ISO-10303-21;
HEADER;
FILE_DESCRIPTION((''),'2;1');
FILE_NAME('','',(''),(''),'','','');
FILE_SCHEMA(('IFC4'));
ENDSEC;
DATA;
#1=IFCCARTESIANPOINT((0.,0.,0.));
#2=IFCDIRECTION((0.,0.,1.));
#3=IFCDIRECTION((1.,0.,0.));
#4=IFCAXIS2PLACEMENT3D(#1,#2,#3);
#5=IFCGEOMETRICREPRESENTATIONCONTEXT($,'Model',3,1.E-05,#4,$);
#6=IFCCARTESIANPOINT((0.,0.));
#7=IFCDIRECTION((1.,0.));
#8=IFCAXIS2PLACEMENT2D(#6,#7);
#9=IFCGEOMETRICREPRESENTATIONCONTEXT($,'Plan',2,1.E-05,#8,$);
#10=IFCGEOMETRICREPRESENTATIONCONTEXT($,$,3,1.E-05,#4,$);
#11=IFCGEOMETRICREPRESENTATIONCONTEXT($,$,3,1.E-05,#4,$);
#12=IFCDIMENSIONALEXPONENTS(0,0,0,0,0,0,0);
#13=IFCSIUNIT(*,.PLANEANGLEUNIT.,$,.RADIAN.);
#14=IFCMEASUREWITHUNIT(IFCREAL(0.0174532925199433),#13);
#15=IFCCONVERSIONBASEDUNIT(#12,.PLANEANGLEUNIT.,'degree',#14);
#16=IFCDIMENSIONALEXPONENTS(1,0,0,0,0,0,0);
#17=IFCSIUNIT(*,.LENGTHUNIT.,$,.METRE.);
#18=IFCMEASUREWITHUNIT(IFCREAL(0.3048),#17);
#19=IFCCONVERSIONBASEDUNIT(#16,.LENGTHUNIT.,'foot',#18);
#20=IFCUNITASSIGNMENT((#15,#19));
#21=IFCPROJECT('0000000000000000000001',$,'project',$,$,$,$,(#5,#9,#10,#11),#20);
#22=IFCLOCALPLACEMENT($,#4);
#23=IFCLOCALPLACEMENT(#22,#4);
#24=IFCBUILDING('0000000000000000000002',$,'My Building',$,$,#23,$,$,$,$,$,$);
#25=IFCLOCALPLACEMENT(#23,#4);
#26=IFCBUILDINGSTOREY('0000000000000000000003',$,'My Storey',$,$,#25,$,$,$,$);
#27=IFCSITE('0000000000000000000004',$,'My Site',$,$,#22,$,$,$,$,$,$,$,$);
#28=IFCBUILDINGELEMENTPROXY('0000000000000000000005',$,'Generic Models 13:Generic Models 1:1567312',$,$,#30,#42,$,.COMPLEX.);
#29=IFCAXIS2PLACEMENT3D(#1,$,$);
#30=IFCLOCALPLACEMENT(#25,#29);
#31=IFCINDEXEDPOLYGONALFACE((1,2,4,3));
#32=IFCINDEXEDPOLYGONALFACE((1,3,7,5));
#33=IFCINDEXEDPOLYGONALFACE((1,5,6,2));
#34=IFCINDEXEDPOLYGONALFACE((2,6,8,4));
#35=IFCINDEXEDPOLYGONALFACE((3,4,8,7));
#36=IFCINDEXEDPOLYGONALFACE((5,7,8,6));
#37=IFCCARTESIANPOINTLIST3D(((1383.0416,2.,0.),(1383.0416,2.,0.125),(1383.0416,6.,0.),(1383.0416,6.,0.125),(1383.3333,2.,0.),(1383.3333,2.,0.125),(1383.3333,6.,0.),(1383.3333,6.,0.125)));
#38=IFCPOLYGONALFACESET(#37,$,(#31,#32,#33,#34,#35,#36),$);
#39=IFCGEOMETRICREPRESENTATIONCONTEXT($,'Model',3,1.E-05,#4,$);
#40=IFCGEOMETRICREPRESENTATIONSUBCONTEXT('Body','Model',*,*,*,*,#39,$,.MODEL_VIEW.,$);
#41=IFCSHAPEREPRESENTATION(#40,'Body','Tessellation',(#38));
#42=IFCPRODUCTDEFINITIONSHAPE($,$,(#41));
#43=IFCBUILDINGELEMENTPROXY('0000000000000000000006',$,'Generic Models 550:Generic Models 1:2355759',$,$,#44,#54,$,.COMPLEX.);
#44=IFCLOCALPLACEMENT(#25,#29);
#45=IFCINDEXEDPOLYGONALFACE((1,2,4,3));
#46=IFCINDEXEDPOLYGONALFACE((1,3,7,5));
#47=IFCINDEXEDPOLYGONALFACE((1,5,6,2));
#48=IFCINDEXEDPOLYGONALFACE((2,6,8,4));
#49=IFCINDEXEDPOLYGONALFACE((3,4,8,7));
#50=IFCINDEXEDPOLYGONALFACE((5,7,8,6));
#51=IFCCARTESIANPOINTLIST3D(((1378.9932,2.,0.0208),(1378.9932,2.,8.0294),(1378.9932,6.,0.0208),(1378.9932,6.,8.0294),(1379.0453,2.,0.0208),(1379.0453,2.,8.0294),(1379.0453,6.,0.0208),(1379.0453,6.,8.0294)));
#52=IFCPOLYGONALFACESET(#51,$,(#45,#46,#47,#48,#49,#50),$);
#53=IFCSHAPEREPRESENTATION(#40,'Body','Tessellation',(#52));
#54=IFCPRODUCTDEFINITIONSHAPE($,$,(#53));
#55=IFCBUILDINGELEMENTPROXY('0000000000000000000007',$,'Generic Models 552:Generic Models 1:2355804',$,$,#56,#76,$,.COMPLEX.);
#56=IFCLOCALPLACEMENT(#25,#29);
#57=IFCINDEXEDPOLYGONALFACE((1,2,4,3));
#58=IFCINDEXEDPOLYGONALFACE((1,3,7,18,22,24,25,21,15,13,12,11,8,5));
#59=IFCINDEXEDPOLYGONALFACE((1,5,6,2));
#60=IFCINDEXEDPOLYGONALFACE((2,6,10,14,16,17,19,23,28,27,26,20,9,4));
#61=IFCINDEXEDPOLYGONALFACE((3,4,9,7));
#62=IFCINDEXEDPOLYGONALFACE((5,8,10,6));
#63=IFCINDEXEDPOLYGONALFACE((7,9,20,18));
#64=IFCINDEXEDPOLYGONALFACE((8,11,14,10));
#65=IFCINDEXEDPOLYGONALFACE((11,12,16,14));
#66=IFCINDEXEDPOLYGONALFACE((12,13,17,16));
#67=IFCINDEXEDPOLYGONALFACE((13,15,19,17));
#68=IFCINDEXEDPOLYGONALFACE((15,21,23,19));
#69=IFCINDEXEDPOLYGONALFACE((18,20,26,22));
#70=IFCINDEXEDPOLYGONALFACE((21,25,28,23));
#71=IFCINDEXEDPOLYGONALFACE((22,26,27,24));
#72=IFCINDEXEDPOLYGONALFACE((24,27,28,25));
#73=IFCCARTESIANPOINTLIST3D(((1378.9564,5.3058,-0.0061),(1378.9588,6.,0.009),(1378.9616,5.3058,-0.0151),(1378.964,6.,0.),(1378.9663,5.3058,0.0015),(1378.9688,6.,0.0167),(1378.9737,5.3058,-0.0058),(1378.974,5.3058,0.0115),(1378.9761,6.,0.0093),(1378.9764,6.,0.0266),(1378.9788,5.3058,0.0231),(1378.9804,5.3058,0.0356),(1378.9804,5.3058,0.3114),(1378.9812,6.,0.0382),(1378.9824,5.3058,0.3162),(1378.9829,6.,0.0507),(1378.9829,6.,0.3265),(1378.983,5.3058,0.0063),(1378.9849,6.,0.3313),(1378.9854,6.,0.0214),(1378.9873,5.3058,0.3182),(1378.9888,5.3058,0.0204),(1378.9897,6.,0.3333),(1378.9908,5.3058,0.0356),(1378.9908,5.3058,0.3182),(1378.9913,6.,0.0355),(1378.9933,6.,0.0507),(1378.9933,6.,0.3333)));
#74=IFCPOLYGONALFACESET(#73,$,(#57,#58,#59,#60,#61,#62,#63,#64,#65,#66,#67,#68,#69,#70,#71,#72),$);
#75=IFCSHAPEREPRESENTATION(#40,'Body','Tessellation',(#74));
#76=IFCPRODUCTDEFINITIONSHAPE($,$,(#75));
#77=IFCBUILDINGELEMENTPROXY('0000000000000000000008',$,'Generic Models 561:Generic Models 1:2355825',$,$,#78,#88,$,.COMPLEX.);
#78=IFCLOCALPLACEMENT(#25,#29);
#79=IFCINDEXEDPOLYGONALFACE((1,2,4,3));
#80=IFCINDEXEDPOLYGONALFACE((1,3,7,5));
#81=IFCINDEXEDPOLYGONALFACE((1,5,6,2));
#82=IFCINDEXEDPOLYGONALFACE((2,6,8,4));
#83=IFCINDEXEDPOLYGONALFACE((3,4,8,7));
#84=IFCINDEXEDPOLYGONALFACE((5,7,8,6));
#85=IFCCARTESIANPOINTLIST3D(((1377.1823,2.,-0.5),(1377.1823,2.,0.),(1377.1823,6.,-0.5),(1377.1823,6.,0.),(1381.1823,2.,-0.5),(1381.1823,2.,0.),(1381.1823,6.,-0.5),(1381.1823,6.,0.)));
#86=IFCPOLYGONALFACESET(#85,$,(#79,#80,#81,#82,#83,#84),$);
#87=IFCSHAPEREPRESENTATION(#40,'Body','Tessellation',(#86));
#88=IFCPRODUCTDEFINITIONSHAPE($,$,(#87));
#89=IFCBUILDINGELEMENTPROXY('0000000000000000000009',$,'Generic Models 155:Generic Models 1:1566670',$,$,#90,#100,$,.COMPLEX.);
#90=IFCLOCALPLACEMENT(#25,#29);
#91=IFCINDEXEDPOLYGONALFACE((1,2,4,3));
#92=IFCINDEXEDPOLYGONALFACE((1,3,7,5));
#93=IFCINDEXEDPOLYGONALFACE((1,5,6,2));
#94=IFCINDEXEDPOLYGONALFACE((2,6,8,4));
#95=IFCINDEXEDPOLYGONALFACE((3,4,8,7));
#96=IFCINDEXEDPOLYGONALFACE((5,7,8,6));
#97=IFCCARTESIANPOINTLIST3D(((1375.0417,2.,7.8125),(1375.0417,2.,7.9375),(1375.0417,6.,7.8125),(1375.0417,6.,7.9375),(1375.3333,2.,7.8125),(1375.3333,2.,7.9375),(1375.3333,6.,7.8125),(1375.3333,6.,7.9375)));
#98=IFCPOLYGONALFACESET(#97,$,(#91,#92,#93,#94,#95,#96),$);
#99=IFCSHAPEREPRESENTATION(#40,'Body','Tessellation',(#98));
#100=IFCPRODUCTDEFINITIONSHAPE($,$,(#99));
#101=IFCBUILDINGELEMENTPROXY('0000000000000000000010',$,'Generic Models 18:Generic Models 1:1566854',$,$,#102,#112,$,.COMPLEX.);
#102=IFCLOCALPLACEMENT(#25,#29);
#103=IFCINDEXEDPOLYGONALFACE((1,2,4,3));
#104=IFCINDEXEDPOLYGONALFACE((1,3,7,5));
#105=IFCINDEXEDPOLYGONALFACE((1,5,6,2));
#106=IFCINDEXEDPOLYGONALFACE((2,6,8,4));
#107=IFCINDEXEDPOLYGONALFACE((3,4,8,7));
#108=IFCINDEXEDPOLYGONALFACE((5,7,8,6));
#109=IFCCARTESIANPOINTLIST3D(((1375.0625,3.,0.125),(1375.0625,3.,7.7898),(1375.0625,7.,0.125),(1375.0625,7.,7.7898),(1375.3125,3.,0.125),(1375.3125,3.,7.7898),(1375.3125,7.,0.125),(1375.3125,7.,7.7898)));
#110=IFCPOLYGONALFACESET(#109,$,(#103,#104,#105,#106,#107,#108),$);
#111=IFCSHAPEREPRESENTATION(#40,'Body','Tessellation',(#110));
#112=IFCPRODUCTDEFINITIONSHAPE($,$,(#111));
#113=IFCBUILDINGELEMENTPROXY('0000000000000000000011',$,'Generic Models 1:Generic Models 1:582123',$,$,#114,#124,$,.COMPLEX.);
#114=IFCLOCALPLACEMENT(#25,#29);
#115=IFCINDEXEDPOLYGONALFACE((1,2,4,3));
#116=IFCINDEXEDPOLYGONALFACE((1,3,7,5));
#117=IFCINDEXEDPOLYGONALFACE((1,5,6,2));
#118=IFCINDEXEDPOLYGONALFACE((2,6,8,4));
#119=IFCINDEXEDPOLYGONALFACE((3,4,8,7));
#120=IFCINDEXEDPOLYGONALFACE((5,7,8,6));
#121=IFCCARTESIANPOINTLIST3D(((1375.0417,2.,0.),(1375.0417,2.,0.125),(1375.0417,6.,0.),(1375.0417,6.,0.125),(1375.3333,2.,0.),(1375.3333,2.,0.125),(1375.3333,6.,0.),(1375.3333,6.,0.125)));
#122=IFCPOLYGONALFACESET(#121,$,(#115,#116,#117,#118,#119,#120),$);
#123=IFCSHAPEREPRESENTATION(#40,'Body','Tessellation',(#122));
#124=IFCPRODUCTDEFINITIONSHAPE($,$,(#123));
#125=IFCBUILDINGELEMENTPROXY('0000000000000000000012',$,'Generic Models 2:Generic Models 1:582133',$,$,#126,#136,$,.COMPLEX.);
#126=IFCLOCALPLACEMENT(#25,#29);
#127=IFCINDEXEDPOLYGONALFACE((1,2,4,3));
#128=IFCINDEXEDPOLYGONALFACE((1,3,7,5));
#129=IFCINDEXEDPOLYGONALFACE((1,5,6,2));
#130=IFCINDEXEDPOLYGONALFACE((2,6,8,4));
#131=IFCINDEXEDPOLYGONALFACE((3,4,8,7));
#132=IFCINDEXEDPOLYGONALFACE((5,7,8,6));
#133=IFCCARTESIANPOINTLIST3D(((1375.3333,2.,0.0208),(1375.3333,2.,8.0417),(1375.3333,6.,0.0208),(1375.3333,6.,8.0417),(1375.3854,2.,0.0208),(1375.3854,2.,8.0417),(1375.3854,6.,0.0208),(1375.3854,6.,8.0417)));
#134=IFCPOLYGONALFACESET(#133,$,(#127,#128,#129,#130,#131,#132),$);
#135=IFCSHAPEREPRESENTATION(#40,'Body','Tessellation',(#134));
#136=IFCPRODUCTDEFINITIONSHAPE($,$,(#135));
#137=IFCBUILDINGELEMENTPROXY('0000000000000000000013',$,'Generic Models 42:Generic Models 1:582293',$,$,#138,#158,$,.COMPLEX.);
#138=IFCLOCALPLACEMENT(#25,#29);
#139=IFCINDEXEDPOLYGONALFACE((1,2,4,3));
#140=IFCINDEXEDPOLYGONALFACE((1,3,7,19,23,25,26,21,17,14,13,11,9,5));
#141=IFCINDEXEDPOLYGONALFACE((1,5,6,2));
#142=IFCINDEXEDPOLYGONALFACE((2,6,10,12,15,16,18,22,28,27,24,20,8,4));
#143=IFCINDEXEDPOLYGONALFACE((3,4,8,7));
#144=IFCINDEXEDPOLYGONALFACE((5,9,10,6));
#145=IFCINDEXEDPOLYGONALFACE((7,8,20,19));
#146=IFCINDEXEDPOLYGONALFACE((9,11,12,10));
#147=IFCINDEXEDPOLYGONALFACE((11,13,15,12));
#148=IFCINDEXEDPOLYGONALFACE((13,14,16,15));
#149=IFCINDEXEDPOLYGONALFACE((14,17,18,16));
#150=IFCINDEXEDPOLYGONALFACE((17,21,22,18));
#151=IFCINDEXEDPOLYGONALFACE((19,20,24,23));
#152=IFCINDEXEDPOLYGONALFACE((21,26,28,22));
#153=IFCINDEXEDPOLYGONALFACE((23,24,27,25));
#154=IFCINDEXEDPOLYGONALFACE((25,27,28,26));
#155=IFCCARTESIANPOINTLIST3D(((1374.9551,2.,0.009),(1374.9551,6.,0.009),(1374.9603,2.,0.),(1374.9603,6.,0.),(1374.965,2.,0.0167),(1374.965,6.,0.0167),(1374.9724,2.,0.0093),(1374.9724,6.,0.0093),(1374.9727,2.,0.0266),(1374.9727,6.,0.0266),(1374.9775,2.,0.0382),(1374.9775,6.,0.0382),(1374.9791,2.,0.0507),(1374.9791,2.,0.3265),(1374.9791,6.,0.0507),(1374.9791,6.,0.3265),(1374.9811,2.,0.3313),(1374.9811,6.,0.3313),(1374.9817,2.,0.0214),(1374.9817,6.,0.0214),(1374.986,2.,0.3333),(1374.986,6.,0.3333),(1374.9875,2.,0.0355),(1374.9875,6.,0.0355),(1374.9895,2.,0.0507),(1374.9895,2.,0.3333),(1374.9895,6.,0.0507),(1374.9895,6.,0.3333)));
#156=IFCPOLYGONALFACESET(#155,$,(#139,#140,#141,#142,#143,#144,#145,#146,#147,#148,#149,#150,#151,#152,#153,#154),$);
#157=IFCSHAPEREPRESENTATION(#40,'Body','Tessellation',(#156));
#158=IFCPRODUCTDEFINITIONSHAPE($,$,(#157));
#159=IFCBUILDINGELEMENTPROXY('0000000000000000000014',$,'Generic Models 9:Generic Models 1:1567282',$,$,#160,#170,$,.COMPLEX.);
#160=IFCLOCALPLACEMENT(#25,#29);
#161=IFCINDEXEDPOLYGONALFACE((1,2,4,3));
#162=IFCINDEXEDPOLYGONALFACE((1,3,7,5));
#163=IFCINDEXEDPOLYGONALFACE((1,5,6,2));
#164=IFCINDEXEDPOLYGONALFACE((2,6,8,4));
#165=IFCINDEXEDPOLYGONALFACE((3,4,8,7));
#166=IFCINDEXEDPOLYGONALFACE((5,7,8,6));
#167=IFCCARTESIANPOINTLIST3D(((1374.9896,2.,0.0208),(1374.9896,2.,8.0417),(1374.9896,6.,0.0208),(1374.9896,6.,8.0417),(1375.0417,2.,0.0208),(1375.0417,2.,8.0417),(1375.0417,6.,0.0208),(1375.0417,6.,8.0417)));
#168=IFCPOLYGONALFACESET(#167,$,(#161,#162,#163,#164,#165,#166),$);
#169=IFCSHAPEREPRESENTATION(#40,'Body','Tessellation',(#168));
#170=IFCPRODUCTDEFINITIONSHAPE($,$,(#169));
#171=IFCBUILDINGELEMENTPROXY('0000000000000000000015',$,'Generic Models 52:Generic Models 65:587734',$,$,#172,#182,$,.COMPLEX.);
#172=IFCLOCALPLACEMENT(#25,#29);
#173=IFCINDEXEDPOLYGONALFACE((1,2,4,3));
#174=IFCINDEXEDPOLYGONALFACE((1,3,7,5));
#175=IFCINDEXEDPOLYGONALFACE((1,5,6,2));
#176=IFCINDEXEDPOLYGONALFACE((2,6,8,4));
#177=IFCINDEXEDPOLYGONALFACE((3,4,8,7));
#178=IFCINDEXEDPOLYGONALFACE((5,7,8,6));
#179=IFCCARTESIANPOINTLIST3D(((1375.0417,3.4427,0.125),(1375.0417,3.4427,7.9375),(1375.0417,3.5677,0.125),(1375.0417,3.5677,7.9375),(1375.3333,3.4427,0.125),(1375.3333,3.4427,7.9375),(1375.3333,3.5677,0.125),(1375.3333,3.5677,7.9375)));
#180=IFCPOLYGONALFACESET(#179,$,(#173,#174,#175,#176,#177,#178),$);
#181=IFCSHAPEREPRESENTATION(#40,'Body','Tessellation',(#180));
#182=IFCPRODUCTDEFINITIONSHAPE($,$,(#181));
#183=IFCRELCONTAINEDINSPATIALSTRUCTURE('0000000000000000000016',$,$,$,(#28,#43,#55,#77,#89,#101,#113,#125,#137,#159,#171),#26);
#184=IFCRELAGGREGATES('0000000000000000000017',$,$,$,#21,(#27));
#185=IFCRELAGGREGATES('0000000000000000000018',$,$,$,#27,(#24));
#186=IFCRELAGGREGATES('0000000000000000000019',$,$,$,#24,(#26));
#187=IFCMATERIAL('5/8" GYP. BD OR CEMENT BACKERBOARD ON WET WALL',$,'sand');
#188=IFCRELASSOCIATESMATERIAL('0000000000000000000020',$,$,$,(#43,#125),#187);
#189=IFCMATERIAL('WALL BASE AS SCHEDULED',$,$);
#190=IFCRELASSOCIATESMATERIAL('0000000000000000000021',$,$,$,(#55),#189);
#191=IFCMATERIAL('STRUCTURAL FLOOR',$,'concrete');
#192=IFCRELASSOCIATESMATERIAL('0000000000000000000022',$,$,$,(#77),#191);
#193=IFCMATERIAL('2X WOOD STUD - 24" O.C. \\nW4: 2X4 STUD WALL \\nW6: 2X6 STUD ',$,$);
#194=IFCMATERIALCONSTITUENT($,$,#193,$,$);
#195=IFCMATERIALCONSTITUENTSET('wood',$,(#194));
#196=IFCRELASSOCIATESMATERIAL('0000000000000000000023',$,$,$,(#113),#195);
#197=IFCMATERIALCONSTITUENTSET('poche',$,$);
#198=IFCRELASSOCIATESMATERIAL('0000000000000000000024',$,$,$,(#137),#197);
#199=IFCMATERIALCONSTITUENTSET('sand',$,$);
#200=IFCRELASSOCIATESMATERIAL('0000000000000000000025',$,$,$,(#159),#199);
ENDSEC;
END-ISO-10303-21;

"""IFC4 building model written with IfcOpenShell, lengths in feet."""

from ifc_helpers import new_model, entity, si_unit, converted_unit, frame, origin_with_axes, origin_2d_with_axis, place, context, subcontext, project, spatial, polyline, outline, extrude, material, constituent, constituent_set, element, save


model = new_model("IFC4")

# Units and contexts
model_context_1 = context("Model", 3, precision=1e-05, world=origin_with_axes())
plan_context = context("Plan", 2, precision=1e-05, world=origin_2d_with_axis())
model_context_2 = context("Model", 3, precision=1e-05, world=origin_with_axes())
context_of_model_1 = context(None, 3, precision=1e-05, world=origin_with_axes())
context_of_model_2 = context(None, 3, precision=1e-05, world=origin_with_axes())
body_context = subcontext(model_context_2, "Body", "Model", "MODEL_VIEW")
ifc_project = project(units=[converted_unit("PLANEANGLEUNIT", "degree", entity("IfcReal", 0.0174532925199433), si_unit("PLANEANGLEUNIT", "RADIAN"), dimensions=[0, 0, 0, 0, 0, 0, 0]), converted_unit("LENGTHUNIT", "foot", entity("IfcReal", 0.3048), si_unit("LENGTHUNIT", "METRE"), dimensions=[1, 0, 0, 0, 0, 0, 0])], contexts=[model_context_1, plan_context, context_of_model_1, context_of_model_2])

# Site, building, storey
site_placement = place(None, origin_with_axes())
site = spatial("IfcSite", under=ifc_project, at=site_placement, Name="My Site")
building_placement = place(site_placement, origin_with_axes())
building = spatial("IfcBuilding", under=site, at=building_placement, Name="My Building")
storey_placement = place(building_placement, origin_with_axes())
storey = spatial("IfcBuildingStorey", under=building, at=storey_placement, Name="My Storey")

# Building element proxies
proxy_1_placement = place(storey_placement, frame((1383.0416, 6.0, 0.0), z_axis=(0.0, -1.0, 0.0), x_axis=(0.0, 0.0, 1.0)))
element("IfcBuildingElementProxy", 1, at=proxy_1_placement, inside=storey, Name="Generic Models 13:Generic Models 1:1567312", PredefinedType="COMPLEX", context=body_context, shape_type="SweptSolid", body=[
    extrude(outline(polyline([(-0.0625, -0.1458), (0.0625, -0.1458), (0.0625, 0.1458), (-0.0625, 0.1458), (-0.0625, -0.1458)])), frame((0.0625, -0.1458, 0.0), z_axis=(0.0, 0.0, -1.0), x_axis=(1.0, 0.0, 0.0)), (0.0, 0.0, -1.0), 4.0),
])
ifc_material_1 = material(Name="5/8\" GYP. BD OR CEMENT BACKERBOARD ON WET WALL", Category="sand")
proxy_2_placement = place(storey_placement, frame((1378.9932, 6.0, 0.0208), z_axis=(0.0, -1.0, 0.0), x_axis=(0.0, 0.0, 1.0)))
element("IfcBuildingElementProxy", 2, at=proxy_2_placement, inside=storey, material=ifc_material_1, Name="Generic Models 550:Generic Models 1:2355759", PredefinedType="COMPLEX", context=body_context, shape_type="SweptSolid", body=[
    extrude(outline(polyline([(-4.0043, -0.026), (4.0043, -0.026), (4.0043, 0.026), (-4.0043, 0.026), (-4.0043, -0.026)])), frame((4.0043, -0.026, 0.0), z_axis=(0.0, 0.0, -1.0), x_axis=(1.0, 0.0, 0.0)), (0.0, 0.0, -1.0), 4.0),
])
ifc_material_2 = material(Name="WALL BASE AS SCHEDULED")
proxy_3_placement = place(storey_placement, frame((1378.9588, 6.0, 0.0), z_axis=(0.0, -1.0, 0.0), x_axis=(0.0, 0.0, 1.0)))
element("IfcBuildingElementProxy", 3, at=proxy_3_placement, inside=storey, material=ifc_material_2, Name="Generic Models 552:Generic Models 1:2355804", PredefinedType="COMPLEX", context=body_context, shape_type="SweptSolid", body=[
    extrude(outline(polyline([(0.2205, 0.0), (0.2206, 0.0036), (-0.0618, 0.0152), (-0.077, 0.0138), (-0.0914, 0.0086), (-0.1038, -0.0002), (-0.1136, -0.012), (-0.1048, -0.0175), (-0.0968, -0.0079), (-0.0865, -0.0007), (-0.0747, 0.0037), (-0.0622, 0.0048), (0.2133, -0.0066), (0.2183, -0.0048), (0.2205, 0.0)])), frame((0.113, -0.0218, 0.0), z_axis=(0.0, 0.0, -1.0), x_axis=(0.999153, -0.041137, 0.0)), (-0.02192, -0.002617, -0.999756), 0.6943),
])
ifc_material_3 = material(Name="STRUCTURAL FLOOR", Category="concrete")
proxy_4_placement = place(storey_placement, frame((1377.1823, 6.0, -0.5), z_axis=(0.0, -1.0, 0.0), x_axis=(0.0, 0.0, 1.0)))
element("IfcBuildingElementProxy", 4, at=proxy_4_placement, inside=storey, material=ifc_material_3, Name="Generic Models 561:Generic Models 1:2355825", PredefinedType="COMPLEX", context=body_context, shape_type="SweptSolid", body=[
    extrude(outline(polyline([(-0.25, -2.0), (0.25, -2.0), (0.25, 2.0), (-0.25, 2.0), (-0.25, -2.0)])), frame((0.25, -2.0, 0.0), z_axis=(0.0, 0.0, -1.0), x_axis=(1.0, 0.0, 0.0)), (0.0, 0.0, -1.0), 4.0),
])
proxy_5_placement = place(storey_placement, frame((1375.0417, 6.0, 7.8125), z_axis=(0.0, -1.0, 0.0), x_axis=(0.0, 0.0, -1.0)))
element("IfcBuildingElementProxy", 5, at=proxy_5_placement, inside=storey, Name="Generic Models 155:Generic Models 1:1566670", PredefinedType="COMPLEX", context=body_context, shape_type="SweptSolid", body=[
    extrude(outline(polyline([(-0.0625, -0.1458), (0.0625, -0.1458), (0.0625, 0.1458), (-0.0625, 0.1458), (-0.0625, -0.1458)])), frame((-0.0625, 0.1458, 0.0), z_axis=(0.0, 0.0, -1.0), x_axis=(-1.0, 0.0, 0.0)), (0.0, 0.0, -1.0), 4.0),
])
proxy_6_placement = place(storey_placement, frame((1375.0625, 3.0, 0.125), z_axis=(0.0, 1.0, 0.0), x_axis=(0.0, 0.0, -1.0)))
element("IfcBuildingElementProxy", 6, at=proxy_6_placement, inside=storey, Name="Generic Models 18:Generic Models 1:1566854", PredefinedType="COMPLEX", context=body_context, shape_type="SweptSolid", body=[
    extrude(outline(polyline([(-3.8324, -0.125), (3.8324, -0.125), (3.8324, 0.125), (-3.8324, 0.125), (-3.8324, -0.125)])), frame((-3.8324, -0.125, 0.0), z_axis=(0.0, 0.0, -1.0), x_axis=(1.0, 0.0, 0.0)), (0.0, 0.0, -1.0), 4.0),
])
ifc_material_4 = material(Name="2X WOOD STUD - 24\" O.C. \\nW4: 2X4 STUD WALL \\nW6: 2X6 STUD ")
ifc_constituent = constituent(ifc_material_4)
ifc_constituent_set_1 = constituent_set(constituents=[ifc_constituent], Name="wood")
proxy_7_placement = place(storey_placement, frame((1375.0417, 6.0, 0.0), z_axis=(0.0, -1.0, 0.0), x_axis=(0.0, 0.0, -1.0)))
element("IfcBuildingElementProxy", 7, at=proxy_7_placement, inside=storey, material=ifc_constituent_set_1, Name="Generic Models 1:Generic Models 1:582123", PredefinedType="COMPLEX", context=body_context, shape_type="SweptSolid", body=[
    extrude(outline(polyline([(-0.0625, -0.1458), (0.0625, -0.1458), (0.0625, 0.1458), (-0.0625, 0.1458), (-0.0625, -0.1458)])), frame((-0.0625, 0.1458, 0.0), z_axis=(0.0, 0.0, -1.0), x_axis=(1.0, 0.0, 0.0)), (0.0, 0.0, -1.0), 4.0),
])
proxy_8_placement = place(storey_placement, frame((1375.3333, 6.0, 0.0208), z_axis=(0.0, -1.0, 0.0), x_axis=(0.0, 0.0, -1.0)))
element("IfcBuildingElementProxy", 8, at=proxy_8_placement, inside=storey, material=ifc_material_1, Name="Generic Models 2:Generic Models 1:582133", PredefinedType="COMPLEX", context=body_context, shape_type="SweptSolid", body=[
    extrude(outline(polyline([(-4.0104, -0.026), (4.0104, -0.026), (4.0104, 0.026), (-4.0104, 0.026), (-4.0104, -0.026)])), frame((-4.0104, 0.026, 0.0), z_axis=(0.0, 0.0, -1.0), x_axis=(1.0, 0.0, 0.0)), (0.0, 0.0, -1.0), 4.0),
])
ifc_constituent_set_2 = constituent_set(Name="poche")
proxy_9_placement = place(storey_placement, frame((1374.9551, 6.0, 0.0), z_axis=(0.0, -1.0, 0.0), x_axis=(0.0, 0.0, -1.0)))
element("IfcBuildingElementProxy", 9, at=proxy_9_placement, inside=storey, material=ifc_constituent_set_2, Name="Generic Models 42:Generic Models 1:582293", PredefinedType="COMPLEX", context=body_context, shape_type="SweptSolid", body=[
    extrude(outline(polyline([(0.0865, 0.0), (0.0747, -0.0042), (0.0622, -0.0053), (-0.2133, 0.0082), (-0.2182, 0.0064), (-0.2205, 0.0017), (-0.2206, -0.0019), (0.0617, -0.0157), (0.0769, -0.0144), (0.0913, -0.0093), (0.1038, -0.0006), (0.1137, 0.0111), (0.105, 0.0167), (0.0968, 0.0072), (0.0865, 0.0)])), frame((-0.113, 0.0218, 0.0), z_axis=(0.0, 0.0, -1.0), x_axis=(0.998808, -0.048806, 0.0)), (0.0, 0.0, -1.0), 4.0),
])
ifc_constituent_set_3 = constituent_set(Name="sand")
proxy_10_placement = place(storey_placement, frame((1374.9896, 6.0, 0.0208), z_axis=(0.0, -1.0, 0.0), x_axis=(0.0, 0.0, -1.0)))
element("IfcBuildingElementProxy", 10, at=proxy_10_placement, inside=storey, material=ifc_constituent_set_3, Name="Generic Models 9:Generic Models 1:1567282", PredefinedType="COMPLEX", context=body_context, shape_type="SweptSolid", body=[
    extrude(outline(polyline([(-0.026, -4.0104), (0.026, -4.0104), (0.026, 4.0104), (-0.026, 4.0104), (-0.026, -4.0104)])), frame((-4.0104, 0.026, 0.0), z_axis=(0.0, 0.0, -1.0), x_axis=(0.0, -1.0, 0.0)), (0.0, 0.0, -1.0), 4.0),
])
proxy_11_placement = place(storey_placement, frame((1375.0417, 3.4427, 0.125), z_axis=(1.0, 0.0, 0.0), x_axis=(0.0, 0.0, -1.0)))
element("IfcBuildingElementProxy", 11, at=proxy_11_placement, inside=storey, Name="Generic Models 52:Generic Models 65:587734", PredefinedType="COMPLEX", context=body_context, shape_type="SweptSolid", body=[
    extrude(outline(polyline([(-3.9062, -0.0625), (3.9062, -0.0625), (3.9062, 0.0625), (-3.9062, 0.0625), (-3.9062, -0.0625)])), frame((-3.9062, 0.0625, 0.0), z_axis=(0.0, 0.0, -1.0), x_axis=(-1.0, 0.0, 0.0)), (0.0, 0.0, -1.0), 0.2917),
])

save(model, "model.ifc")
